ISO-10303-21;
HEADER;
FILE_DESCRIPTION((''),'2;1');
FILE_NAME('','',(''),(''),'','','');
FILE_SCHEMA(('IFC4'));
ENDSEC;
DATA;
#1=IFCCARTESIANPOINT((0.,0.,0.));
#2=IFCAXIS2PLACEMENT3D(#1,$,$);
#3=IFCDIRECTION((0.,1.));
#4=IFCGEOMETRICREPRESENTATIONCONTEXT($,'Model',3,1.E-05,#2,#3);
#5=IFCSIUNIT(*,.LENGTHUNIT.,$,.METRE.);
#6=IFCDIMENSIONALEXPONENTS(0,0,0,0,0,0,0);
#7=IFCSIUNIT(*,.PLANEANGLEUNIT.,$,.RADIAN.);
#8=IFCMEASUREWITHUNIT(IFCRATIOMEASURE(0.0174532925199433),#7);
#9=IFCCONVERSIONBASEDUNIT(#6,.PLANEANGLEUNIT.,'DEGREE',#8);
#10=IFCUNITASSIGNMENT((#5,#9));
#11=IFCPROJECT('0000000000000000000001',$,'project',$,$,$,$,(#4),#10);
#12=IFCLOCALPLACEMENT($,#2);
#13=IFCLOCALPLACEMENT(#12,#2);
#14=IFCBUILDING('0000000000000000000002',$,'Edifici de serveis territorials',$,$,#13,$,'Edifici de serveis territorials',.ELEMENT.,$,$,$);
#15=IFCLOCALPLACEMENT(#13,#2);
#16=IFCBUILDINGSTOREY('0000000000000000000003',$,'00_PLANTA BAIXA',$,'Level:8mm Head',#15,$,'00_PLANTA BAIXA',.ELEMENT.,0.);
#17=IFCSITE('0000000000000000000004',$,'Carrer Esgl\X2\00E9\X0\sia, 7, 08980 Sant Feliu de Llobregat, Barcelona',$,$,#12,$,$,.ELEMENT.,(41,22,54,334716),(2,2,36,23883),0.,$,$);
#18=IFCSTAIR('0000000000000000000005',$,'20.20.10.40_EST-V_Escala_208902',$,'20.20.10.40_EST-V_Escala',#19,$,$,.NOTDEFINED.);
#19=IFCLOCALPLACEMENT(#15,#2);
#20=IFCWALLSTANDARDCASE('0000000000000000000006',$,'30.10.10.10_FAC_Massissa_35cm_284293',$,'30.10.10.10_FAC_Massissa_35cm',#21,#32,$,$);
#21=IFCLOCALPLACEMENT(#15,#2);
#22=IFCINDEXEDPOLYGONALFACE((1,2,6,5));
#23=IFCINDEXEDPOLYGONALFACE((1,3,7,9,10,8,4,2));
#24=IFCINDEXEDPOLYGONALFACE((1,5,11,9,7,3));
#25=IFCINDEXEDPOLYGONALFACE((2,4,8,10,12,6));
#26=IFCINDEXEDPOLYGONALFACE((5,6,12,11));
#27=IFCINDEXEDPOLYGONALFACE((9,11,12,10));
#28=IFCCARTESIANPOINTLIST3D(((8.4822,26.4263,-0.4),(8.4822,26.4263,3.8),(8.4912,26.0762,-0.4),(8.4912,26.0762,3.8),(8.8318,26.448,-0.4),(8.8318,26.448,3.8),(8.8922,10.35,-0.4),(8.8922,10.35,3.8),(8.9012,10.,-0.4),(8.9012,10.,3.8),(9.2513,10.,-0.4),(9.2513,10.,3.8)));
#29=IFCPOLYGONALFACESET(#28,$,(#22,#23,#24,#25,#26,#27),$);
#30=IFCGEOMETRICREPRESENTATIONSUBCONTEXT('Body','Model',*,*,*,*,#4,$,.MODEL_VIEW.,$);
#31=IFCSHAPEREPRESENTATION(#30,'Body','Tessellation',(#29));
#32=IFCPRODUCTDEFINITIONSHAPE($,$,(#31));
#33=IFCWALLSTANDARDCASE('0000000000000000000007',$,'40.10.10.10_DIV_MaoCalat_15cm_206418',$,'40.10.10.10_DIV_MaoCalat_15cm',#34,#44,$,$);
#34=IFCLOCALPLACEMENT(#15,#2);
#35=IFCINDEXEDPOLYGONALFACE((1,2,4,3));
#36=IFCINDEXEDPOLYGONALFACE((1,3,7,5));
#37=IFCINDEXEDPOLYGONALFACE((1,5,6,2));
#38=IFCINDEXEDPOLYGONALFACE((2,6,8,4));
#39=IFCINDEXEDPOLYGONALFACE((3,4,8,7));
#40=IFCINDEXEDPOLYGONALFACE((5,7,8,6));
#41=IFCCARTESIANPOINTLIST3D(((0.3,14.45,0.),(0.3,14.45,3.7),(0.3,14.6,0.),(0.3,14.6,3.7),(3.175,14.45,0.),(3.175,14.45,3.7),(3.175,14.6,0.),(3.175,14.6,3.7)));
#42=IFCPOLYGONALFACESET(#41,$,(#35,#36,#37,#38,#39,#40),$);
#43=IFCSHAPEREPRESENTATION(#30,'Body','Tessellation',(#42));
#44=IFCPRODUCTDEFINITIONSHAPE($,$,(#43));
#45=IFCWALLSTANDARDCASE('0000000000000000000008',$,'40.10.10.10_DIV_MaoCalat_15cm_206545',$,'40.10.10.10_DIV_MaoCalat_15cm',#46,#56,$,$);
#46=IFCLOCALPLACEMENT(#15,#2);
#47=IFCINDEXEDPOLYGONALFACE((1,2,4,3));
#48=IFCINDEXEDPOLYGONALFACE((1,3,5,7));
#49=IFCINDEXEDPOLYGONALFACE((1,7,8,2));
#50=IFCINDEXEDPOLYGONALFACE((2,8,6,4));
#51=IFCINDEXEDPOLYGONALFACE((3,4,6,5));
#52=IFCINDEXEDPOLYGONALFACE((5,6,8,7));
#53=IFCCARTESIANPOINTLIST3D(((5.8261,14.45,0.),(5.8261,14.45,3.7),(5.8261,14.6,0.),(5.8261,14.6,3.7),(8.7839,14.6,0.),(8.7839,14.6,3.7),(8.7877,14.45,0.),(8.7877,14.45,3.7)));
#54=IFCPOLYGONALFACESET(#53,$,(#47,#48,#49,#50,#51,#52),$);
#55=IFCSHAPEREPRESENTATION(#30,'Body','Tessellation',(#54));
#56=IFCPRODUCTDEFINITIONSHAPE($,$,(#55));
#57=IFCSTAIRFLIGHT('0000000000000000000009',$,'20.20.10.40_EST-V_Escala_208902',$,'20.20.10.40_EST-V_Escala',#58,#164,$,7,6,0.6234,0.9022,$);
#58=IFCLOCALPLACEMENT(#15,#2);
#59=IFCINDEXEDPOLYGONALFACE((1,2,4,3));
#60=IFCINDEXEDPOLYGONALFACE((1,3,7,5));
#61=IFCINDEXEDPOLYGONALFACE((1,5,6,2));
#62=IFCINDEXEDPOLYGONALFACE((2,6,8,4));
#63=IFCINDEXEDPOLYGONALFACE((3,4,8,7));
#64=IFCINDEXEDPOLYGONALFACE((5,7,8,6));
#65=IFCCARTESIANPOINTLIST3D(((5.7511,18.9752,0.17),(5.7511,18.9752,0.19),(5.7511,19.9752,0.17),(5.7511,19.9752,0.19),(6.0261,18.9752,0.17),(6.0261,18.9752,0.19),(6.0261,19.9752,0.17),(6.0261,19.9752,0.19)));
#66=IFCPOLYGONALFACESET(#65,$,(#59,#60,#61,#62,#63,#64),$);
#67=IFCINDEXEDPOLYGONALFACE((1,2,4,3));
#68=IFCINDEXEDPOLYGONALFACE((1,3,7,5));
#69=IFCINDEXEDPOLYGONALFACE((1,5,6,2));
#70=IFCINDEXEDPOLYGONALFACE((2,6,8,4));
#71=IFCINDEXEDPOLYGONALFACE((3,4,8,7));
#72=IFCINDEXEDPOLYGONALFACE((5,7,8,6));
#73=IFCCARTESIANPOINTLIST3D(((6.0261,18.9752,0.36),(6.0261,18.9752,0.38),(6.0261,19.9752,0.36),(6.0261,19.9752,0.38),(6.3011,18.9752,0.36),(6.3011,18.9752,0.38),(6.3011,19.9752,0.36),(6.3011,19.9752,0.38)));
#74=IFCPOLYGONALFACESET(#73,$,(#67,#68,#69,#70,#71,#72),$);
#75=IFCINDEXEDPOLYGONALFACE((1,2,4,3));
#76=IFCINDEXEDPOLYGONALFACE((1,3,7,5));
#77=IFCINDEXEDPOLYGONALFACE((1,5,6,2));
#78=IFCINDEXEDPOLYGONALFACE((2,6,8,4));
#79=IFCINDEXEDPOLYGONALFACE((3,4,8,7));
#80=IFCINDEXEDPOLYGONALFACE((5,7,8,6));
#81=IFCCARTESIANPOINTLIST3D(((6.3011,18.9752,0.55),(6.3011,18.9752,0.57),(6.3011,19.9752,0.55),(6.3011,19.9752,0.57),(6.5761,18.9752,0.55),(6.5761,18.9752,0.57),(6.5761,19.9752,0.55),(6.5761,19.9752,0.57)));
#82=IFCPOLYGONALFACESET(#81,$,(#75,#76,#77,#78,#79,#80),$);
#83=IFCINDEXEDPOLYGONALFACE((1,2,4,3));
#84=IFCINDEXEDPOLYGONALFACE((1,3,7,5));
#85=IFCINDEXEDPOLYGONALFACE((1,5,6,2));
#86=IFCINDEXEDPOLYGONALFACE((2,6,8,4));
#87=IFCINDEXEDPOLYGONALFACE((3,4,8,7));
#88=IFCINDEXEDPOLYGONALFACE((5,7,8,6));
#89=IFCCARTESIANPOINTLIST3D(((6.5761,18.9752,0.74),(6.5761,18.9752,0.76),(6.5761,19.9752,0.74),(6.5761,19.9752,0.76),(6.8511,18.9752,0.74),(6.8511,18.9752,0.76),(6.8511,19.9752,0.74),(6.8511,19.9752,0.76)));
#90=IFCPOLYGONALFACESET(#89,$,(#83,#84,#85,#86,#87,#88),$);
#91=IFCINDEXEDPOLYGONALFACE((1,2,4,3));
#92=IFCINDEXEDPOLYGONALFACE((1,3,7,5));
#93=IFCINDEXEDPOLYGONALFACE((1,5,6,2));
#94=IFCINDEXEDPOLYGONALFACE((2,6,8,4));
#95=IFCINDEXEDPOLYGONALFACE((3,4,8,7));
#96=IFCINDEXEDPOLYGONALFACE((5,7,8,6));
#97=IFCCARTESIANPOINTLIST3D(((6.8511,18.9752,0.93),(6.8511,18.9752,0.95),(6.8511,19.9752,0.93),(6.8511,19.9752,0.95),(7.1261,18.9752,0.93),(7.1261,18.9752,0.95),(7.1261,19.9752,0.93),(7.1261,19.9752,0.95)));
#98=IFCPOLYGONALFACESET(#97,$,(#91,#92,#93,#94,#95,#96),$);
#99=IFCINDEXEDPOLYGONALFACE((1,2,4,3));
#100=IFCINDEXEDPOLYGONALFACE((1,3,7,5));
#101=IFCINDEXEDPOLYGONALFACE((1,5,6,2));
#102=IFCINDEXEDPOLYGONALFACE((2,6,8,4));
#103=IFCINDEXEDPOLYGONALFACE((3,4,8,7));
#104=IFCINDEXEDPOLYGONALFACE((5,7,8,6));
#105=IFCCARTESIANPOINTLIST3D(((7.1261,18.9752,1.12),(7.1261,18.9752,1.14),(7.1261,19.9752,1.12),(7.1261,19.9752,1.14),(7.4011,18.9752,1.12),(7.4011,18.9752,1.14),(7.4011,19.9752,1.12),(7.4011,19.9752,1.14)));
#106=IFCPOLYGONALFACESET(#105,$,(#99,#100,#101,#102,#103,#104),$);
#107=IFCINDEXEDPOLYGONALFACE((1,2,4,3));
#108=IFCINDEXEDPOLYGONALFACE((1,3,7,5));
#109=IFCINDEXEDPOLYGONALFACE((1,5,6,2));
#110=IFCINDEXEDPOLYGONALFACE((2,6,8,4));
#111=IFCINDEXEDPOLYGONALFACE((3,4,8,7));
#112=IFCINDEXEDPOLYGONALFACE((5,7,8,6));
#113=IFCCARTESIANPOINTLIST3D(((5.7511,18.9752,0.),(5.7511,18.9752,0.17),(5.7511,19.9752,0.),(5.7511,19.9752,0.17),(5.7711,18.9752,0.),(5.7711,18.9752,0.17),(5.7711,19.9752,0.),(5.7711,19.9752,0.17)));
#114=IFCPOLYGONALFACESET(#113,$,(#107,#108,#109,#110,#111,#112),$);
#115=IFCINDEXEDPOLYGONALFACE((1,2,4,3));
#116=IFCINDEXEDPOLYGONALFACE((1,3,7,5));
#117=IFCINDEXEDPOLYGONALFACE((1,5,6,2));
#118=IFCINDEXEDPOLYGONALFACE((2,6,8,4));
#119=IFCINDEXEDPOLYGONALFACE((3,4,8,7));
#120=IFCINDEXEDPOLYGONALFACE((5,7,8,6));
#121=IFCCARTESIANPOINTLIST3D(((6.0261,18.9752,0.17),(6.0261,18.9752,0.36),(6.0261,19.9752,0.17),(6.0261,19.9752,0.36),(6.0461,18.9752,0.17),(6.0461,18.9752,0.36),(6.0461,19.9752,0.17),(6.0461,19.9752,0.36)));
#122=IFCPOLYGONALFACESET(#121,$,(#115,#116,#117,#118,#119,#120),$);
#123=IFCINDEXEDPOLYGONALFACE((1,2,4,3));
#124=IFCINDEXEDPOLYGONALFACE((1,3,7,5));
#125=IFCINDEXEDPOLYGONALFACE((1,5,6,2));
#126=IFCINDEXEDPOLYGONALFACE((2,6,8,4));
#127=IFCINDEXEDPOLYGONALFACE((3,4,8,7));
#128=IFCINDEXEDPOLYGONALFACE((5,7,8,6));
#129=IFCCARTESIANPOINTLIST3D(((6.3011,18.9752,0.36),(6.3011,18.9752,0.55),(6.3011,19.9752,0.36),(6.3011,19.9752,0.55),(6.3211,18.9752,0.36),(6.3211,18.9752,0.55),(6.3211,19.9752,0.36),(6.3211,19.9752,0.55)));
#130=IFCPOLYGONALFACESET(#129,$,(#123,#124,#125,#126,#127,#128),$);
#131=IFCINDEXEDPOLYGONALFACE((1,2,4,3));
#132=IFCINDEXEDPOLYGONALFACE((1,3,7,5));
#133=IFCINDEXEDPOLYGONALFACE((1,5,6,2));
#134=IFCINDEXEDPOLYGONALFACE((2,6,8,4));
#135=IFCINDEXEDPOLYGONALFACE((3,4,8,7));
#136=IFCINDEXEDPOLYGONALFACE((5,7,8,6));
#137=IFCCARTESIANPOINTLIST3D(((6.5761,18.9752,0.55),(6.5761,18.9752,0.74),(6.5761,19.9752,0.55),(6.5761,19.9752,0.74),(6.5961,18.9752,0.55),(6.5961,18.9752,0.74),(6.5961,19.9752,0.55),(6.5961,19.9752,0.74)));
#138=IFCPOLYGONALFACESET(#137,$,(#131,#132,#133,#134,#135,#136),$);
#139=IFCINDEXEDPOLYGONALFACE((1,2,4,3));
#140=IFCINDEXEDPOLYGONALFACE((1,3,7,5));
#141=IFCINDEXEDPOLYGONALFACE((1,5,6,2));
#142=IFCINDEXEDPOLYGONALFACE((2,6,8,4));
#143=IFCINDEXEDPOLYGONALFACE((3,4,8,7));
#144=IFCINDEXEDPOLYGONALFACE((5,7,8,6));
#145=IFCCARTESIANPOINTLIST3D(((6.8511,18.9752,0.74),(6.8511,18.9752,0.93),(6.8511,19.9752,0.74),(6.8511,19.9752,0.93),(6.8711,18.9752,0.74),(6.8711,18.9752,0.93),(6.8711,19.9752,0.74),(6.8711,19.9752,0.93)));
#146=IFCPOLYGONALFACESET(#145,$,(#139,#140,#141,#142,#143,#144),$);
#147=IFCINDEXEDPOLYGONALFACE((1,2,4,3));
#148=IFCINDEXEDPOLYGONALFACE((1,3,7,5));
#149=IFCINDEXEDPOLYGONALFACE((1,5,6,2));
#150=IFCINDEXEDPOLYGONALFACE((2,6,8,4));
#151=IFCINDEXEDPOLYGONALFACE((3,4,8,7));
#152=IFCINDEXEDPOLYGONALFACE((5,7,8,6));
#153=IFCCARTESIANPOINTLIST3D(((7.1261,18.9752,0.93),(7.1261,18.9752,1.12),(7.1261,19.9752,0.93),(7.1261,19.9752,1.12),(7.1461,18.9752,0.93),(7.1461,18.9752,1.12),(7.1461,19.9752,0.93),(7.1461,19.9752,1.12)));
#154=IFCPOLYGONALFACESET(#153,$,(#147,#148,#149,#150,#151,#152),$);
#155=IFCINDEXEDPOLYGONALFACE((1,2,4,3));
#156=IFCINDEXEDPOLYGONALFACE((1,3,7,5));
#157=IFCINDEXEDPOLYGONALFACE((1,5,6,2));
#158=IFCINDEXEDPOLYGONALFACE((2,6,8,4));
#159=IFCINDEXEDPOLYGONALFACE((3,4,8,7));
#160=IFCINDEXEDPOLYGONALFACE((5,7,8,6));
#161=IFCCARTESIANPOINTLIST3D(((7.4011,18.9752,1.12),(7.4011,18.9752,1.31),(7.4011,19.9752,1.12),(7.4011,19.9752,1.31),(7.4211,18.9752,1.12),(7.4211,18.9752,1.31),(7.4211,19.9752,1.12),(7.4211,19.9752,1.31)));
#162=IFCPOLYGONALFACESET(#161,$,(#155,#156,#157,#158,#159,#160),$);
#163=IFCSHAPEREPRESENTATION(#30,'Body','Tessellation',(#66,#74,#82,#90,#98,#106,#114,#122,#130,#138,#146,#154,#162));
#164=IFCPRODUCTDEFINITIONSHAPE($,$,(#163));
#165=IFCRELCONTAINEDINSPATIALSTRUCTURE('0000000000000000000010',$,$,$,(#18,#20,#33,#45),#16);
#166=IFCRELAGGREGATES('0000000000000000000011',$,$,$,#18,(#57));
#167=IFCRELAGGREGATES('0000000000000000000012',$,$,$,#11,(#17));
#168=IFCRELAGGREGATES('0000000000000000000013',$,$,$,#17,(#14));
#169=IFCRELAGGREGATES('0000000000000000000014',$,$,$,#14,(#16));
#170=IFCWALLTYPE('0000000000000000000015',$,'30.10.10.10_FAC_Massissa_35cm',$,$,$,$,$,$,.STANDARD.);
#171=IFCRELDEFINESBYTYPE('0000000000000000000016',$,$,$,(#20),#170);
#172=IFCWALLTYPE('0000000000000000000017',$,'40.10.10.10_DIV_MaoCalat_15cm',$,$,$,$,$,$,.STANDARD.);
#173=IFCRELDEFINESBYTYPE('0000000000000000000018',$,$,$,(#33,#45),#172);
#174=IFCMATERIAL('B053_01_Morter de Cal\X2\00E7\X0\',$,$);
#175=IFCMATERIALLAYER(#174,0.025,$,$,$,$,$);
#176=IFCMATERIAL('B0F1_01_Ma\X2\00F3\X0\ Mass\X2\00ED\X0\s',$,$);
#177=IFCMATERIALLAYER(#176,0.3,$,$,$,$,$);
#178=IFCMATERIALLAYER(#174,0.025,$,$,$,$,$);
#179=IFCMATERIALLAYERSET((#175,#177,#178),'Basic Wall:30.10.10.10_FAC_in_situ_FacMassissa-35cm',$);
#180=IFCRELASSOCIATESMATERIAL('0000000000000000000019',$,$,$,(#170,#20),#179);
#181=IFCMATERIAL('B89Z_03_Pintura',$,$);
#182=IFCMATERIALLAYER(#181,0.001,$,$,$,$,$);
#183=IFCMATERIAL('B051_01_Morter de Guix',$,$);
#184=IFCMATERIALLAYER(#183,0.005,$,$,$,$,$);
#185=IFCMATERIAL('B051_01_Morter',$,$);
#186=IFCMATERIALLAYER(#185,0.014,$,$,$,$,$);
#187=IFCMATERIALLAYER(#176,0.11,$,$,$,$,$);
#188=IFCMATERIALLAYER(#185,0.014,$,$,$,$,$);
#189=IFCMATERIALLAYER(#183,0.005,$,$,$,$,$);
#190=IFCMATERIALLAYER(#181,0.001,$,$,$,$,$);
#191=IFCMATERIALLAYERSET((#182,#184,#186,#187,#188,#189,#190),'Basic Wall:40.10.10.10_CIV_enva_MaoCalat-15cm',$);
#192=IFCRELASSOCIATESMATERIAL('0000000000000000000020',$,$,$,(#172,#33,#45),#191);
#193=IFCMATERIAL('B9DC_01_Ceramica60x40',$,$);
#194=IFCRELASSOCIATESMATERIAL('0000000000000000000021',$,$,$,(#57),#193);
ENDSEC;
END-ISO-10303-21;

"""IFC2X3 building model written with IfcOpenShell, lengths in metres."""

from ifc_helpers import new_model, entity, si_unit, converted_unit, direction, frame, frame_2d, origin, place, context, subcontext, project, spatial, polyline, rectangle, outline, extrude, material, layer, layer_set, layer_usage, type_object, element, aggregate, save


model = new_model("IFC2X3")

# Units and contexts
model_context = context("Model", 3, precision=1e-05, world=origin(), true_north=direction((0.0, 1.0)))
body_context = subcontext(model_context, "Body", "Model", "MODEL_VIEW")
ifc_project = project(units=[si_unit("LENGTHUNIT", "METRE"), converted_unit("PLANEANGLEUNIT", "DEGREE", entity("IfcRatioMeasure", 0.0174532925199433), si_unit("PLANEANGLEUNIT", "RADIAN"), dimensions=[0, 0, 0, 0, 0, 0, 0])], contexts=[model_context])

# Site, building, storey
site_placement = place(None, origin())
site = spatial("IfcSite", under=ifc_project, at=site_placement, Name="Carrer Església, 7, 08980 Sant Feliu de Llobregat, Barcelona", CompositionType="ELEMENT", RefLatitude=(41, 22, 54, 334716), RefLongitude=(2, 2, 36, 23883), RefElevation=0.0)
building_placement = place(site_placement, origin())
building = spatial("IfcBuilding", under=site, at=building_placement, Name="Edifici de serveis territorials", LongName="Edifici de serveis territorials", CompositionType="ELEMENT")
storey_placement = place(building_placement, origin())
storey = spatial("IfcBuildingStorey", under=building, at=storey_placement, Name="00_PLANTA BAIXA", ObjectType="Level:8mm Head", LongName="00_PLANTA BAIXA", CompositionType="ELEMENT", Elevation=0.0)

# Shared definitions
ifc_material_1 = material(Name="B9DC_01_Ceramica60x40")
ifc_material_2 = material(Name="B051_01_Morter")

# Stair
stair_placement = place(storey_placement, origin())
stair = element("IfcStair", 1, at=stair_placement, inside=storey, Name="20.20.10.40_EST-V_Escala_208902", ObjectType="20.20.10.40_EST-V_Escala", ShapeType="NOTDEFINED")

# Wall
ifc_material_3 = material(Name="B053_01_Morter de Calç")
ifc_layer_1 = layer(ifc_material_3, 0.025)
ifc_material_4 = material(Name="B0F1_01_Maó Massís")
ifc_layer_2 = layer(ifc_material_4, 0.3)
ifc_layer_3 = layer(ifc_material_3, 0.025)
ifc_layer_set_1 = layer_set([ifc_layer_1, ifc_layer_2, ifc_layer_3], Name="Basic Wall:30.10.10.10_FAC_in_situ_FacMassissa-35cm")
ifc_layer_usage_1 = layer_usage(ifc_layer_set_1, "AXIS2", "POSITIVE", -0.175)
wall_type_1 = type_object("IfcWallType", Name="30.10.10.10_FAC_Massissa_35cm", PredefinedType="STANDARD", material=ifc_layer_set_1)
wall_1_placement = place(storey_placement, frame((9.0763, 9.9955, -0.4), z_axis=(0.0, 0.0, 1.0), x_axis=(-0.025497, 0.999675, 0.0)))
element("IfcWallStandardCase", 2, at=wall_1_placement, inside=storey, type_object=wall_type_1, material=ifc_layer_usage_1, Name="30.10.10.10_FAC_Massissa_35cm_284293", ObjectType="30.10.10.10_FAC_Massissa_35cm", context=body_context, shape_type="SweptSolid", body=[
    extrude(outline(polyline([(16.4533, -0.175), (16.4406, 0.175), (16.0904, 0.175), (0.359, 0.175), (0.0089, 0.175), (0.0, -0.175), (16.4533, -0.175)])), origin(), (0.0, 0.0, 1.0), 4.2),
])

# Shared definitions
ifc_material_5 = material(Name="B89Z_03_Pintura")

# Walls
ifc_layer_4 = layer(ifc_material_5, 0.001)
ifc_material_6 = material(Name="B051_01_Morter de Guix")
ifc_layer_5 = layer(ifc_material_6, 0.005)
ifc_layer_6 = layer(ifc_material_2, 0.014)
ifc_layer_7 = layer(ifc_material_4, 0.11)
ifc_layer_8 = layer(ifc_material_2, 0.014)
ifc_layer_9 = layer(ifc_material_6, 0.005)
ifc_layer_10 = layer(ifc_material_5, 0.001)
ifc_layer_set_2 = layer_set([ifc_layer_4, ifc_layer_5, ifc_layer_6, ifc_layer_7, ifc_layer_8, ifc_layer_9, ifc_layer_10], Name="Basic Wall:40.10.10.10_CIV_enva_MaoCalat-15cm")
ifc_layer_usage_2 = layer_usage(ifc_layer_set_2, "AXIS2", "NEGATIVE", 0.075)
wall_type_2 = type_object("IfcWallType", Name="40.10.10.10_DIV_MaoCalat_15cm", PredefinedType="STANDARD", material=ifc_layer_set_2)
wall_2_placement = place(storey_placement, frame((0.3, 14.525, 0.0)))
element("IfcWallStandardCase", 3, at=wall_2_placement, inside=storey, type_object=wall_type_2, material=ifc_layer_usage_2, Name="40.10.10.10_DIV_MaoCalat_15cm_206418", ObjectType="40.10.10.10_DIV_MaoCalat_15cm", context=body_context, shape_type="SweptSolid", body=[
    extrude(rectangle(XDim=2.875, YDim=0.15, at=frame_2d((1.4375, 0.0), x_axis=(-1.0, 0.0))), origin(), (0.0, 0.0, 1.0), 3.7),
])
ifc_layer_usage_3 = layer_usage(ifc_layer_set_2, "AXIS2", "NEGATIVE", 0.075)
wall_3_placement = place(storey_placement, frame((8.7877, 14.525, 0.0), z_axis=(0.0, 0.0, 1.0), x_axis=(-1.0, 0.0, 0.0)))
element("IfcWallStandardCase", 4, at=wall_3_placement, inside=storey, type_object=wall_type_2, material=ifc_layer_usage_3, Name="40.10.10.10_DIV_MaoCalat_15cm_206545", ObjectType="40.10.10.10_DIV_MaoCalat_15cm", context=body_context, shape_type="SweptSolid", body=[
    extrude(outline(polyline([(2.9616, -0.075), (2.9616, 0.075), (0.0, 0.075), (0.0038, -0.075), (2.9616, -0.075)])), origin(), (0.0, 0.0, 1.0), 3.7),
])

# Stair flight
stair_flight_1_placement = place(stair_placement, origin())
stair_flight_1 = element("IfcStairFlight", 5, at=stair_flight_1_placement, material=ifc_material_1, Name="20.20.10.40_EST-V_Escala_208902", ObjectType="20.20.10.40_EST-V_Escala", NumberOfRiser=7, NumberOfTreads=6, RiserHeight=0.6234, TreadLength=0.9022, context=body_context, shape_type="SweptSolid", body=[
    extrude(rectangle(XDim=0.275, YDim=1.0, at=frame_2d((0.0, 0.0), x_axis=(1.0, 0.0))), frame((5.8886, 19.4752, 0.17), z_axis=(0.0, 0.0, 1.0), x_axis=(-1.0, 0.0, 0.0)), (0.0, 0.0, 1.0), 0.02),
    extrude(rectangle(XDim=0.275, YDim=1.0, at=frame_2d((0.0, 0.0), x_axis=(1.0, 0.0))), frame((6.1636, 19.4752, 0.36), z_axis=(0.0, 0.0, 1.0), x_axis=(-1.0, 0.0, 0.0)), (0.0, 0.0, 1.0), 0.02),
    extrude(rectangle(XDim=0.275, YDim=1.0, at=frame_2d((0.0, 0.0), x_axis=(1.0, 0.0))), frame((6.4386, 19.4752, 0.55), z_axis=(0.0, 0.0, 1.0), x_axis=(-1.0, 0.0, 0.0)), (0.0, 0.0, 1.0), 0.02),
    extrude(rectangle(XDim=0.275, YDim=1.0, at=frame_2d((0.0, 0.0), x_axis=(1.0, 0.0))), frame((6.7136, 19.4752, 0.74), z_axis=(0.0, 0.0, 1.0), x_axis=(-1.0, 0.0, 0.0)), (0.0, 0.0, 1.0), 0.02),
    extrude(rectangle(XDim=0.275, YDim=1.0, at=frame_2d((0.0, 0.0), x_axis=(1.0, 0.0))), frame((6.9886, 19.4752, 0.93), z_axis=(0.0, 0.0, 1.0), x_axis=(-1.0, 0.0, 0.0)), (0.0, 0.0, 1.0), 0.02),
    extrude(rectangle(XDim=0.275, YDim=1.0, at=frame_2d((0.0, 0.0), x_axis=(1.0, 0.0))), frame((7.2636, 19.4752, 1.12), z_axis=(0.0, 0.0, 1.0), x_axis=(-1.0, 0.0, 0.0)), (0.0, 0.0, 1.0), 0.02),
    extrude(rectangle(XDim=1.0, YDim=0.02, at=frame_2d((0.0, 0.0), x_axis=(1.0, 0.0))), frame((5.7611, 19.4752, 0.0), z_axis=(0.0, 0.0, 1.0), x_axis=(0.0, 1.0, 0.0)), (0.0, 0.0, 1.0), 0.17),
    extrude(rectangle(XDim=1.0, YDim=0.02, at=frame_2d((0.0, 0.0), x_axis=(1.0, 0.0))), frame((6.0361, 19.4752, 0.17), z_axis=(0.0, 0.0, 1.0), x_axis=(0.0, 1.0, 0.0)), (0.0, 0.0, 1.0), 0.19),
    extrude(rectangle(XDim=1.0, YDim=0.02, at=frame_2d((0.0, 0.0), x_axis=(1.0, 0.0))), frame((6.3111, 19.4752, 0.36), z_axis=(0.0, 0.0, 1.0), x_axis=(0.0, 1.0, 0.0)), (0.0, 0.0, 1.0), 0.19),
    extrude(rectangle(XDim=1.0, YDim=0.02, at=frame_2d((0.0, 0.0), x_axis=(1.0, 0.0))), frame((6.5861, 19.4752, 0.55), z_axis=(0.0, 0.0, 1.0), x_axis=(0.0, 1.0, 0.0)), (0.0, 0.0, 1.0), 0.19),
    extrude(rectangle(XDim=1.0, YDim=0.02, at=frame_2d((0.0, 0.0), x_axis=(1.0, 0.0))), frame((6.8611, 19.4752, 0.74), z_axis=(0.0, 0.0, 1.0), x_axis=(0.0, 1.0, 0.0)), (0.0, 0.0, 1.0), 0.19),
    extrude(rectangle(XDim=1.0, YDim=0.02, at=frame_2d((0.0, 0.0), x_axis=(1.0, 0.0))), frame((7.1361, 19.4752, 0.93), z_axis=(0.0, 0.0, 1.0), x_axis=(0.0, 1.0, 0.0)), (0.0, 0.0, 1.0), 0.19),
    extrude(outline(polyline([(-0.5, -0.01), (0.5, -0.01), (0.5, 0.01), (-0.5, 0.01), (-0.5, -0.01)])), frame((7.4111, 19.4752, 1.12), z_axis=(0.0, 0.0, 1.0), x_axis=(0.0, 1.0, 0.0)), (0.0, 0.0, 1.0), 0.19),
])
aggregate(stair, [stair_flight_1])

save(model, "model.ifc")
